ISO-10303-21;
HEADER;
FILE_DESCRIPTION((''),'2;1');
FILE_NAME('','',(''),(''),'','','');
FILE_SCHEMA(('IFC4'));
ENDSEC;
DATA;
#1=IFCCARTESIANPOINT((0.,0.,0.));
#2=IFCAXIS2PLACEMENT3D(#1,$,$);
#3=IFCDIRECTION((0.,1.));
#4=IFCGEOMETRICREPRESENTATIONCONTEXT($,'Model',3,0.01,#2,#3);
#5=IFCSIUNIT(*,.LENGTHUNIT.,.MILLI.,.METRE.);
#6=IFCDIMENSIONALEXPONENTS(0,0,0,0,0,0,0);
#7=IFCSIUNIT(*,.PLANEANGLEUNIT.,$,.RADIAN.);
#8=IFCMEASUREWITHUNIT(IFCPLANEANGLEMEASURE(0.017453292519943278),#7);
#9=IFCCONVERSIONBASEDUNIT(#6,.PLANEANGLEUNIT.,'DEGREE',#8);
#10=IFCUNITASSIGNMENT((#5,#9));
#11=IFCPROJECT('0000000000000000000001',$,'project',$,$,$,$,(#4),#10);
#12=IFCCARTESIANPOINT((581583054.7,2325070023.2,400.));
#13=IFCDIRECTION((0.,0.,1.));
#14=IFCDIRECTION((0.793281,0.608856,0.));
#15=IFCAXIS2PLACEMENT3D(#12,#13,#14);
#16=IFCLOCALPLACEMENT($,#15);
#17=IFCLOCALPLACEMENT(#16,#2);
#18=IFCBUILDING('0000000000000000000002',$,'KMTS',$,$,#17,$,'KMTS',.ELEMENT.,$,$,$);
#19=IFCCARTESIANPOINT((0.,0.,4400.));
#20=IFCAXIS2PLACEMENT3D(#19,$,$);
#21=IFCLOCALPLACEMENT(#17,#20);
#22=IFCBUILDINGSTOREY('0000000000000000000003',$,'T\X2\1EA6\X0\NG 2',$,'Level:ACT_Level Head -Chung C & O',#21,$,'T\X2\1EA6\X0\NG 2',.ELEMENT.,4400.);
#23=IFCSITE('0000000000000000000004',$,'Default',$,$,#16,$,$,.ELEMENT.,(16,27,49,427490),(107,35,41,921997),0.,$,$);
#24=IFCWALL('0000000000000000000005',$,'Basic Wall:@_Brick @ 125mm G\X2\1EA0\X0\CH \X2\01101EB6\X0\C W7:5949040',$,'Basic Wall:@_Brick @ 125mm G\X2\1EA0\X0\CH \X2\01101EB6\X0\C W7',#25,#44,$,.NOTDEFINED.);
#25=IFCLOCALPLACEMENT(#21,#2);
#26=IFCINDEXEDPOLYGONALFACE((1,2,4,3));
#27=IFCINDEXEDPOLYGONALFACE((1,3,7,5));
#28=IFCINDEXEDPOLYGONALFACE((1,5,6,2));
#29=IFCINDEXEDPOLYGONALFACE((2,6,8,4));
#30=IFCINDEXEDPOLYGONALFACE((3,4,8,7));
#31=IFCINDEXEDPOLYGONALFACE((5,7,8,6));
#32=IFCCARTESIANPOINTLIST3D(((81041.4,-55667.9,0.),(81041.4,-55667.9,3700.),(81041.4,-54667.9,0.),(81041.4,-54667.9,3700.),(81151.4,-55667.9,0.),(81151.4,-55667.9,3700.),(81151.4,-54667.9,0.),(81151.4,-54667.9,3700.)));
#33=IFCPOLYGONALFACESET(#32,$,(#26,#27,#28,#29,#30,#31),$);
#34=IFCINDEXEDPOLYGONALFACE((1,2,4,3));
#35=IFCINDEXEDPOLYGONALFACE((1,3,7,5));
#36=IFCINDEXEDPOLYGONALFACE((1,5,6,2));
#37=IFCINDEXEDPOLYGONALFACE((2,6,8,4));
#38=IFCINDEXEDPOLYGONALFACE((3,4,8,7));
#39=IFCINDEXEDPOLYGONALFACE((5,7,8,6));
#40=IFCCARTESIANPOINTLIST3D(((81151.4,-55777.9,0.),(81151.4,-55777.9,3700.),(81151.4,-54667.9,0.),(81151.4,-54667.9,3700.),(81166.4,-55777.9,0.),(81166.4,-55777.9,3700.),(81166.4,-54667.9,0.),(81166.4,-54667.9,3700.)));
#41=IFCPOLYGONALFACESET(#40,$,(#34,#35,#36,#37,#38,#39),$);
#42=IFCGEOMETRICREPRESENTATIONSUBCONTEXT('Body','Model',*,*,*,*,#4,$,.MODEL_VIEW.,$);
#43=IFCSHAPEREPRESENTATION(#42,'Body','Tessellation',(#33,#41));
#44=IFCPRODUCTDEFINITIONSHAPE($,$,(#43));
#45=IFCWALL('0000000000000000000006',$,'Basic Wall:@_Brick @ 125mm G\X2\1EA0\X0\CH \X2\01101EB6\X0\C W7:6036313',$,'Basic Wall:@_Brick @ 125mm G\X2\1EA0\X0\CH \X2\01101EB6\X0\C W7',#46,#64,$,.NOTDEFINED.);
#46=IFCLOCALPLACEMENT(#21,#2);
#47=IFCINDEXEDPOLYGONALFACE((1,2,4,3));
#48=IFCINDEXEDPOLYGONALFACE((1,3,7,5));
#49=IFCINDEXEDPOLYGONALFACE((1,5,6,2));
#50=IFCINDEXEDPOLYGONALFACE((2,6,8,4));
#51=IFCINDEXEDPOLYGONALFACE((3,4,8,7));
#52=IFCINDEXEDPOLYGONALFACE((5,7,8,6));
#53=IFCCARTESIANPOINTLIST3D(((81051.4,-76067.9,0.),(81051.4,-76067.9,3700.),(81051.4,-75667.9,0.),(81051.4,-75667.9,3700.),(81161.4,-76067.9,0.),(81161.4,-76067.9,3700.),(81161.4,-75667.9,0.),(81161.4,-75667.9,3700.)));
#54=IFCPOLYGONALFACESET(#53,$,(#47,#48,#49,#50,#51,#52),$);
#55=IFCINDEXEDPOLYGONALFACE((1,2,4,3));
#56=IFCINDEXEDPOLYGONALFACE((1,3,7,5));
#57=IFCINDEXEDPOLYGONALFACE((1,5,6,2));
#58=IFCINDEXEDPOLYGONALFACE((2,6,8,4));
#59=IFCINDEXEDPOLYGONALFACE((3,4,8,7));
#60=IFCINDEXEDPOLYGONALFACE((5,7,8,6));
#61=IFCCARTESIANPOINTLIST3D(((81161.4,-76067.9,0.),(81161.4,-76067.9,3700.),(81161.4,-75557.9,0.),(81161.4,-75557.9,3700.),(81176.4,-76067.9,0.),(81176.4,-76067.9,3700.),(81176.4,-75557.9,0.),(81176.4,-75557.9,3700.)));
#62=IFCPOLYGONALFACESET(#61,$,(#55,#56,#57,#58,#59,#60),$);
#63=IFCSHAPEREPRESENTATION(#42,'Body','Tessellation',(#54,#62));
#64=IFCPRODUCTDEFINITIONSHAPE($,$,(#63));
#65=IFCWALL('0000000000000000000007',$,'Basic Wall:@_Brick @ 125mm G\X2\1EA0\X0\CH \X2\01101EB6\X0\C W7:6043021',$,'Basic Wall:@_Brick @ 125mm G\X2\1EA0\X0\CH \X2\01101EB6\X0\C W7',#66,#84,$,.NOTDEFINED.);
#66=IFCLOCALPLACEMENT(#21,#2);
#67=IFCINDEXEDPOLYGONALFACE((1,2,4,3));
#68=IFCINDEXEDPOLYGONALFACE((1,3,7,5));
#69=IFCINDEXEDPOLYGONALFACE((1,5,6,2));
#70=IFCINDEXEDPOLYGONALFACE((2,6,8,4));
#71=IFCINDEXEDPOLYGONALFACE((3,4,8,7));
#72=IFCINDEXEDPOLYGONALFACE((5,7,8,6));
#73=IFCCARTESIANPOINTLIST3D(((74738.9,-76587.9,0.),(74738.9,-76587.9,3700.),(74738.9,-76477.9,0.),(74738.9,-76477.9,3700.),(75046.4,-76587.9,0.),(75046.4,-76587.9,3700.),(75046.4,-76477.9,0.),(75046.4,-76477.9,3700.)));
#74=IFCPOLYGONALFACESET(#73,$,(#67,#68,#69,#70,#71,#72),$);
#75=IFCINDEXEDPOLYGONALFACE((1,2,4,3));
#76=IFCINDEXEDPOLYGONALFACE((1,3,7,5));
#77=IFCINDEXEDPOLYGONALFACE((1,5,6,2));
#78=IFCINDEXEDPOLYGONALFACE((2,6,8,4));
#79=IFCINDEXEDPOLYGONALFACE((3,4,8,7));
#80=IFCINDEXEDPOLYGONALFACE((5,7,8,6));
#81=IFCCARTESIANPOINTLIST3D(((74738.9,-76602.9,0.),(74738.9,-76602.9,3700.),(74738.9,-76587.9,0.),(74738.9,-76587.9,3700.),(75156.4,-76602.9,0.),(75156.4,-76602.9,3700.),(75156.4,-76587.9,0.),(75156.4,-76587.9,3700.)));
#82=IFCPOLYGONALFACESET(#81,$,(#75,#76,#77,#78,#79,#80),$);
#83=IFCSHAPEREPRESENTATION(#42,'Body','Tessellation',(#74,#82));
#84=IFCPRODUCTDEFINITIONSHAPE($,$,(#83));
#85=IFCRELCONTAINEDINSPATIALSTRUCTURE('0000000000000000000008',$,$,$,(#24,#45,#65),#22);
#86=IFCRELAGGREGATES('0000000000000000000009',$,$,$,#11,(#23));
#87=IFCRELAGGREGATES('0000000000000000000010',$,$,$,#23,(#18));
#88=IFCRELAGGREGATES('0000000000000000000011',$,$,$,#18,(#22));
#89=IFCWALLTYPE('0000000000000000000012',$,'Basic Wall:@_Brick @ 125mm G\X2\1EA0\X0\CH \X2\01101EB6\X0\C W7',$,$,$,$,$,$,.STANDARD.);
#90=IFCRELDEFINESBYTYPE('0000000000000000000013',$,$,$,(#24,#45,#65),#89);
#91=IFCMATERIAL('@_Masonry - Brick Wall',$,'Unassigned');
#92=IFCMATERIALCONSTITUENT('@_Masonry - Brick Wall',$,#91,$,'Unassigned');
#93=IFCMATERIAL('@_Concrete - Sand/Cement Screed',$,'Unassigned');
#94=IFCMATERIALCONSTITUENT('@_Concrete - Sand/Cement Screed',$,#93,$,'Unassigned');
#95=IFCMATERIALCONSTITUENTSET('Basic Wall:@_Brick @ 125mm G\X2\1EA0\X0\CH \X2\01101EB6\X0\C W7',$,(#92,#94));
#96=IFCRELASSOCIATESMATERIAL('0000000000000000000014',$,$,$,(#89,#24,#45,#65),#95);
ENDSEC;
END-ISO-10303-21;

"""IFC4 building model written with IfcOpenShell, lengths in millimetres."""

from ifc_helpers import new_model, entity, si_unit, converted_unit, direction, frame, origin, place, context, subcontext, project, spatial, indexed_curve, outline, extrude, material, constituent, constituent_set, type_object, element, save


model = new_model("IFC4")

# Units and contexts
model_context = context("Model", 3, precision=0.01, world=origin(), true_north=direction((0.0, 1.0)))
body_context = subcontext(model_context, "Body", "Model", "MODEL_VIEW")
ifc_project = project(units=[si_unit("LENGTHUNIT", "METRE", prefix="MILLI"), converted_unit("PLANEANGLEUNIT", "DEGREE", entity("IfcPlaneAngleMeasure", 0.017453292519943278), si_unit("PLANEANGLEUNIT", "RADIAN"), dimensions=[0, 0, 0, 0, 0, 0, 0])], contexts=[model_context])

# Site, building, storey
site_placement = place(None, frame((581583054.7, 2325070023.2, 400.0), z_axis=(0.0, 0.0, 1.0), x_axis=(0.793281, 0.608856, 0.0)))
site = spatial("IfcSite", under=ifc_project, at=site_placement, Name="Default", CompositionType="ELEMENT", RefLatitude=(16, 27, 49, 427490), RefLongitude=(107, 35, 41, 921997), RefElevation=0.0)
building_placement = place(site_placement, origin())
building = spatial("IfcBuilding", under=site, at=building_placement, Name="KMTS", LongName="KMTS", CompositionType="ELEMENT")
storey_placement = place(building_placement, frame((0.0, 0.0, 4400.0)))
storey = spatial("IfcBuildingStorey", under=building, at=storey_placement, Name="TẦNG 2", ObjectType="Level:ACT_Level Head -Chung C & O", LongName="TẦNG 2", CompositionType="ELEMENT", Elevation=4400.0)

# Walls
ifc_material_1 = material(Name="@_Masonry - Brick Wall", Category="Unassigned")
ifc_constituent_1 = constituent(ifc_material_1, Name="@_Masonry - Brick Wall", Category="Unassigned")
ifc_material_2 = material(Name="@_Concrete - Sand/Cement Screed", Category="Unassigned")
ifc_constituent_2 = constituent(ifc_material_2, Name="@_Concrete - Sand/Cement Screed", Category="Unassigned")
ifc_constituent_set_1 = constituent_set(constituents=[ifc_constituent_1, ifc_constituent_2], Name="Basic Wall:@_Brick @ 125mm GẠCH ĐẶC W7")
wall_type_1 = type_object("IfcWallType", Name="Basic Wall:@_Brick @ 125mm GẠCH ĐẶC W7", PredefinedType="STANDARD", material=ifc_constituent_set_1)
wall_1_placement = place(storey_placement, frame((81103.9, -55667.9, 0.0), z_axis=(0.0, 0.0, 1.0), x_axis=(0.0, 1.0, 0.0)))
element("IfcWall", 1, at=wall_1_placement, inside=storey, type_object=wall_type_1, material=ifc_constituent_set_1, Name="Basic Wall:@_Brick @ 125mm GẠCH ĐẶC W7:5949040", ObjectType="Basic Wall:@_Brick @ 125mm GẠCH ĐẶC W7", PredefinedType="NOTDEFINED", context=body_context, shape_type="SweptSolid", body=[
    extrude(outline(indexed_curve([(-55.0, -500.0), (55.0, -500.0), (55.0, 500.0), (-55.0, 500.0), (-55.0, -500.0)], self_intersect=False)), frame((500.0, 7.5, 0.0), z_axis=(0.0, 0.0, 1.0), x_axis=(0.0, -1.0, 0.0)), (0.0, 0.0, 1.0), 3700.0),
    extrude(outline(indexed_curve([(-7.5, -555.0), (7.5, -555.0), (7.5, 555.0), (-7.5, 555.0), (-7.5, -555.0)], self_intersect=False)), frame((445.0, -55.0, 0.0), z_axis=(0.0, 0.0, 1.0), x_axis=(0.0, 1.0, 0.0)), (0.0, 0.0, 1.0), 3700.0),
])
wall_2_placement = place(storey_placement, frame((81113.9, -76067.9, 0.0), z_axis=(0.0, 0.0, 1.0), x_axis=(0.0, 1.0, 0.0)))
element("IfcWall", 2, at=wall_2_placement, inside=storey, type_object=wall_type_1, material=ifc_constituent_set_1, Name="Basic Wall:@_Brick @ 125mm GẠCH ĐẶC W7:6036313", ObjectType="Basic Wall:@_Brick @ 125mm GẠCH ĐẶC W7", PredefinedType="NOTDEFINED", context=body_context, shape_type="SweptSolid", body=[
    extrude(outline(indexed_curve([(-55.0, -200.0), (55.0, -200.0), (55.0, 200.0), (-55.0, 200.0), (-55.0, -200.0)], self_intersect=False)), frame((200.0, 7.5, 0.0), z_axis=(0.0, 0.0, 1.0), x_axis=(0.0, -1.0, 0.0)), (0.0, 0.0, 1.0), 3700.0),
    extrude(outline(indexed_curve([(-7.5, -255.0), (7.5, -255.0), (7.5, 255.0), (-7.5, 255.0), (-7.5, -255.0)], self_intersect=False)), frame((255.0, -55.0, 0.0), z_axis=(0.0, 0.0, 1.0), x_axis=(0.0, 1.0, 0.0)), (0.0, 0.0, 1.0), 3700.0),
])
wall_3_placement = place(storey_placement, frame((75046.4, -76540.4, 0.0), z_axis=(0.0, 0.0, 1.0), x_axis=(-1.0, 0.0, 0.0)))
element("IfcWall", 3, at=wall_3_placement, inside=storey, type_object=wall_type_1, material=ifc_constituent_set_1, Name="Basic Wall:@_Brick @ 125mm GẠCH ĐẶC W7:6043021", ObjectType="Basic Wall:@_Brick @ 125mm GẠCH ĐẶC W7", PredefinedType="NOTDEFINED", context=body_context, shape_type="SweptSolid", body=[
    extrude(outline(indexed_curve([(-55.0, -153.8), (55.0, -153.7), (55.0, 153.7), (-55.0, 153.7), (-55.0, -153.8)], self_intersect=False)), frame((153.7, -7.5, 0.0), z_axis=(0.0, 0.0, 1.0), x_axis=(0.0, 1.0, 0.0)), (0.0, 0.0, 1.0), 3700.0),
    extrude(outline(indexed_curve([(-7.5, -208.8), (7.5, -208.8), (7.5, 208.8), (-7.5, 208.8), (-7.5, -208.8)], self_intersect=False)), frame((98.7, 55.0, 0.0), z_axis=(0.0, 0.0, 1.0), x_axis=(0.0, -1.0, 0.0)), (0.0, 0.0, 1.0), 3700.0),
])

save(model, "model.ifc")
